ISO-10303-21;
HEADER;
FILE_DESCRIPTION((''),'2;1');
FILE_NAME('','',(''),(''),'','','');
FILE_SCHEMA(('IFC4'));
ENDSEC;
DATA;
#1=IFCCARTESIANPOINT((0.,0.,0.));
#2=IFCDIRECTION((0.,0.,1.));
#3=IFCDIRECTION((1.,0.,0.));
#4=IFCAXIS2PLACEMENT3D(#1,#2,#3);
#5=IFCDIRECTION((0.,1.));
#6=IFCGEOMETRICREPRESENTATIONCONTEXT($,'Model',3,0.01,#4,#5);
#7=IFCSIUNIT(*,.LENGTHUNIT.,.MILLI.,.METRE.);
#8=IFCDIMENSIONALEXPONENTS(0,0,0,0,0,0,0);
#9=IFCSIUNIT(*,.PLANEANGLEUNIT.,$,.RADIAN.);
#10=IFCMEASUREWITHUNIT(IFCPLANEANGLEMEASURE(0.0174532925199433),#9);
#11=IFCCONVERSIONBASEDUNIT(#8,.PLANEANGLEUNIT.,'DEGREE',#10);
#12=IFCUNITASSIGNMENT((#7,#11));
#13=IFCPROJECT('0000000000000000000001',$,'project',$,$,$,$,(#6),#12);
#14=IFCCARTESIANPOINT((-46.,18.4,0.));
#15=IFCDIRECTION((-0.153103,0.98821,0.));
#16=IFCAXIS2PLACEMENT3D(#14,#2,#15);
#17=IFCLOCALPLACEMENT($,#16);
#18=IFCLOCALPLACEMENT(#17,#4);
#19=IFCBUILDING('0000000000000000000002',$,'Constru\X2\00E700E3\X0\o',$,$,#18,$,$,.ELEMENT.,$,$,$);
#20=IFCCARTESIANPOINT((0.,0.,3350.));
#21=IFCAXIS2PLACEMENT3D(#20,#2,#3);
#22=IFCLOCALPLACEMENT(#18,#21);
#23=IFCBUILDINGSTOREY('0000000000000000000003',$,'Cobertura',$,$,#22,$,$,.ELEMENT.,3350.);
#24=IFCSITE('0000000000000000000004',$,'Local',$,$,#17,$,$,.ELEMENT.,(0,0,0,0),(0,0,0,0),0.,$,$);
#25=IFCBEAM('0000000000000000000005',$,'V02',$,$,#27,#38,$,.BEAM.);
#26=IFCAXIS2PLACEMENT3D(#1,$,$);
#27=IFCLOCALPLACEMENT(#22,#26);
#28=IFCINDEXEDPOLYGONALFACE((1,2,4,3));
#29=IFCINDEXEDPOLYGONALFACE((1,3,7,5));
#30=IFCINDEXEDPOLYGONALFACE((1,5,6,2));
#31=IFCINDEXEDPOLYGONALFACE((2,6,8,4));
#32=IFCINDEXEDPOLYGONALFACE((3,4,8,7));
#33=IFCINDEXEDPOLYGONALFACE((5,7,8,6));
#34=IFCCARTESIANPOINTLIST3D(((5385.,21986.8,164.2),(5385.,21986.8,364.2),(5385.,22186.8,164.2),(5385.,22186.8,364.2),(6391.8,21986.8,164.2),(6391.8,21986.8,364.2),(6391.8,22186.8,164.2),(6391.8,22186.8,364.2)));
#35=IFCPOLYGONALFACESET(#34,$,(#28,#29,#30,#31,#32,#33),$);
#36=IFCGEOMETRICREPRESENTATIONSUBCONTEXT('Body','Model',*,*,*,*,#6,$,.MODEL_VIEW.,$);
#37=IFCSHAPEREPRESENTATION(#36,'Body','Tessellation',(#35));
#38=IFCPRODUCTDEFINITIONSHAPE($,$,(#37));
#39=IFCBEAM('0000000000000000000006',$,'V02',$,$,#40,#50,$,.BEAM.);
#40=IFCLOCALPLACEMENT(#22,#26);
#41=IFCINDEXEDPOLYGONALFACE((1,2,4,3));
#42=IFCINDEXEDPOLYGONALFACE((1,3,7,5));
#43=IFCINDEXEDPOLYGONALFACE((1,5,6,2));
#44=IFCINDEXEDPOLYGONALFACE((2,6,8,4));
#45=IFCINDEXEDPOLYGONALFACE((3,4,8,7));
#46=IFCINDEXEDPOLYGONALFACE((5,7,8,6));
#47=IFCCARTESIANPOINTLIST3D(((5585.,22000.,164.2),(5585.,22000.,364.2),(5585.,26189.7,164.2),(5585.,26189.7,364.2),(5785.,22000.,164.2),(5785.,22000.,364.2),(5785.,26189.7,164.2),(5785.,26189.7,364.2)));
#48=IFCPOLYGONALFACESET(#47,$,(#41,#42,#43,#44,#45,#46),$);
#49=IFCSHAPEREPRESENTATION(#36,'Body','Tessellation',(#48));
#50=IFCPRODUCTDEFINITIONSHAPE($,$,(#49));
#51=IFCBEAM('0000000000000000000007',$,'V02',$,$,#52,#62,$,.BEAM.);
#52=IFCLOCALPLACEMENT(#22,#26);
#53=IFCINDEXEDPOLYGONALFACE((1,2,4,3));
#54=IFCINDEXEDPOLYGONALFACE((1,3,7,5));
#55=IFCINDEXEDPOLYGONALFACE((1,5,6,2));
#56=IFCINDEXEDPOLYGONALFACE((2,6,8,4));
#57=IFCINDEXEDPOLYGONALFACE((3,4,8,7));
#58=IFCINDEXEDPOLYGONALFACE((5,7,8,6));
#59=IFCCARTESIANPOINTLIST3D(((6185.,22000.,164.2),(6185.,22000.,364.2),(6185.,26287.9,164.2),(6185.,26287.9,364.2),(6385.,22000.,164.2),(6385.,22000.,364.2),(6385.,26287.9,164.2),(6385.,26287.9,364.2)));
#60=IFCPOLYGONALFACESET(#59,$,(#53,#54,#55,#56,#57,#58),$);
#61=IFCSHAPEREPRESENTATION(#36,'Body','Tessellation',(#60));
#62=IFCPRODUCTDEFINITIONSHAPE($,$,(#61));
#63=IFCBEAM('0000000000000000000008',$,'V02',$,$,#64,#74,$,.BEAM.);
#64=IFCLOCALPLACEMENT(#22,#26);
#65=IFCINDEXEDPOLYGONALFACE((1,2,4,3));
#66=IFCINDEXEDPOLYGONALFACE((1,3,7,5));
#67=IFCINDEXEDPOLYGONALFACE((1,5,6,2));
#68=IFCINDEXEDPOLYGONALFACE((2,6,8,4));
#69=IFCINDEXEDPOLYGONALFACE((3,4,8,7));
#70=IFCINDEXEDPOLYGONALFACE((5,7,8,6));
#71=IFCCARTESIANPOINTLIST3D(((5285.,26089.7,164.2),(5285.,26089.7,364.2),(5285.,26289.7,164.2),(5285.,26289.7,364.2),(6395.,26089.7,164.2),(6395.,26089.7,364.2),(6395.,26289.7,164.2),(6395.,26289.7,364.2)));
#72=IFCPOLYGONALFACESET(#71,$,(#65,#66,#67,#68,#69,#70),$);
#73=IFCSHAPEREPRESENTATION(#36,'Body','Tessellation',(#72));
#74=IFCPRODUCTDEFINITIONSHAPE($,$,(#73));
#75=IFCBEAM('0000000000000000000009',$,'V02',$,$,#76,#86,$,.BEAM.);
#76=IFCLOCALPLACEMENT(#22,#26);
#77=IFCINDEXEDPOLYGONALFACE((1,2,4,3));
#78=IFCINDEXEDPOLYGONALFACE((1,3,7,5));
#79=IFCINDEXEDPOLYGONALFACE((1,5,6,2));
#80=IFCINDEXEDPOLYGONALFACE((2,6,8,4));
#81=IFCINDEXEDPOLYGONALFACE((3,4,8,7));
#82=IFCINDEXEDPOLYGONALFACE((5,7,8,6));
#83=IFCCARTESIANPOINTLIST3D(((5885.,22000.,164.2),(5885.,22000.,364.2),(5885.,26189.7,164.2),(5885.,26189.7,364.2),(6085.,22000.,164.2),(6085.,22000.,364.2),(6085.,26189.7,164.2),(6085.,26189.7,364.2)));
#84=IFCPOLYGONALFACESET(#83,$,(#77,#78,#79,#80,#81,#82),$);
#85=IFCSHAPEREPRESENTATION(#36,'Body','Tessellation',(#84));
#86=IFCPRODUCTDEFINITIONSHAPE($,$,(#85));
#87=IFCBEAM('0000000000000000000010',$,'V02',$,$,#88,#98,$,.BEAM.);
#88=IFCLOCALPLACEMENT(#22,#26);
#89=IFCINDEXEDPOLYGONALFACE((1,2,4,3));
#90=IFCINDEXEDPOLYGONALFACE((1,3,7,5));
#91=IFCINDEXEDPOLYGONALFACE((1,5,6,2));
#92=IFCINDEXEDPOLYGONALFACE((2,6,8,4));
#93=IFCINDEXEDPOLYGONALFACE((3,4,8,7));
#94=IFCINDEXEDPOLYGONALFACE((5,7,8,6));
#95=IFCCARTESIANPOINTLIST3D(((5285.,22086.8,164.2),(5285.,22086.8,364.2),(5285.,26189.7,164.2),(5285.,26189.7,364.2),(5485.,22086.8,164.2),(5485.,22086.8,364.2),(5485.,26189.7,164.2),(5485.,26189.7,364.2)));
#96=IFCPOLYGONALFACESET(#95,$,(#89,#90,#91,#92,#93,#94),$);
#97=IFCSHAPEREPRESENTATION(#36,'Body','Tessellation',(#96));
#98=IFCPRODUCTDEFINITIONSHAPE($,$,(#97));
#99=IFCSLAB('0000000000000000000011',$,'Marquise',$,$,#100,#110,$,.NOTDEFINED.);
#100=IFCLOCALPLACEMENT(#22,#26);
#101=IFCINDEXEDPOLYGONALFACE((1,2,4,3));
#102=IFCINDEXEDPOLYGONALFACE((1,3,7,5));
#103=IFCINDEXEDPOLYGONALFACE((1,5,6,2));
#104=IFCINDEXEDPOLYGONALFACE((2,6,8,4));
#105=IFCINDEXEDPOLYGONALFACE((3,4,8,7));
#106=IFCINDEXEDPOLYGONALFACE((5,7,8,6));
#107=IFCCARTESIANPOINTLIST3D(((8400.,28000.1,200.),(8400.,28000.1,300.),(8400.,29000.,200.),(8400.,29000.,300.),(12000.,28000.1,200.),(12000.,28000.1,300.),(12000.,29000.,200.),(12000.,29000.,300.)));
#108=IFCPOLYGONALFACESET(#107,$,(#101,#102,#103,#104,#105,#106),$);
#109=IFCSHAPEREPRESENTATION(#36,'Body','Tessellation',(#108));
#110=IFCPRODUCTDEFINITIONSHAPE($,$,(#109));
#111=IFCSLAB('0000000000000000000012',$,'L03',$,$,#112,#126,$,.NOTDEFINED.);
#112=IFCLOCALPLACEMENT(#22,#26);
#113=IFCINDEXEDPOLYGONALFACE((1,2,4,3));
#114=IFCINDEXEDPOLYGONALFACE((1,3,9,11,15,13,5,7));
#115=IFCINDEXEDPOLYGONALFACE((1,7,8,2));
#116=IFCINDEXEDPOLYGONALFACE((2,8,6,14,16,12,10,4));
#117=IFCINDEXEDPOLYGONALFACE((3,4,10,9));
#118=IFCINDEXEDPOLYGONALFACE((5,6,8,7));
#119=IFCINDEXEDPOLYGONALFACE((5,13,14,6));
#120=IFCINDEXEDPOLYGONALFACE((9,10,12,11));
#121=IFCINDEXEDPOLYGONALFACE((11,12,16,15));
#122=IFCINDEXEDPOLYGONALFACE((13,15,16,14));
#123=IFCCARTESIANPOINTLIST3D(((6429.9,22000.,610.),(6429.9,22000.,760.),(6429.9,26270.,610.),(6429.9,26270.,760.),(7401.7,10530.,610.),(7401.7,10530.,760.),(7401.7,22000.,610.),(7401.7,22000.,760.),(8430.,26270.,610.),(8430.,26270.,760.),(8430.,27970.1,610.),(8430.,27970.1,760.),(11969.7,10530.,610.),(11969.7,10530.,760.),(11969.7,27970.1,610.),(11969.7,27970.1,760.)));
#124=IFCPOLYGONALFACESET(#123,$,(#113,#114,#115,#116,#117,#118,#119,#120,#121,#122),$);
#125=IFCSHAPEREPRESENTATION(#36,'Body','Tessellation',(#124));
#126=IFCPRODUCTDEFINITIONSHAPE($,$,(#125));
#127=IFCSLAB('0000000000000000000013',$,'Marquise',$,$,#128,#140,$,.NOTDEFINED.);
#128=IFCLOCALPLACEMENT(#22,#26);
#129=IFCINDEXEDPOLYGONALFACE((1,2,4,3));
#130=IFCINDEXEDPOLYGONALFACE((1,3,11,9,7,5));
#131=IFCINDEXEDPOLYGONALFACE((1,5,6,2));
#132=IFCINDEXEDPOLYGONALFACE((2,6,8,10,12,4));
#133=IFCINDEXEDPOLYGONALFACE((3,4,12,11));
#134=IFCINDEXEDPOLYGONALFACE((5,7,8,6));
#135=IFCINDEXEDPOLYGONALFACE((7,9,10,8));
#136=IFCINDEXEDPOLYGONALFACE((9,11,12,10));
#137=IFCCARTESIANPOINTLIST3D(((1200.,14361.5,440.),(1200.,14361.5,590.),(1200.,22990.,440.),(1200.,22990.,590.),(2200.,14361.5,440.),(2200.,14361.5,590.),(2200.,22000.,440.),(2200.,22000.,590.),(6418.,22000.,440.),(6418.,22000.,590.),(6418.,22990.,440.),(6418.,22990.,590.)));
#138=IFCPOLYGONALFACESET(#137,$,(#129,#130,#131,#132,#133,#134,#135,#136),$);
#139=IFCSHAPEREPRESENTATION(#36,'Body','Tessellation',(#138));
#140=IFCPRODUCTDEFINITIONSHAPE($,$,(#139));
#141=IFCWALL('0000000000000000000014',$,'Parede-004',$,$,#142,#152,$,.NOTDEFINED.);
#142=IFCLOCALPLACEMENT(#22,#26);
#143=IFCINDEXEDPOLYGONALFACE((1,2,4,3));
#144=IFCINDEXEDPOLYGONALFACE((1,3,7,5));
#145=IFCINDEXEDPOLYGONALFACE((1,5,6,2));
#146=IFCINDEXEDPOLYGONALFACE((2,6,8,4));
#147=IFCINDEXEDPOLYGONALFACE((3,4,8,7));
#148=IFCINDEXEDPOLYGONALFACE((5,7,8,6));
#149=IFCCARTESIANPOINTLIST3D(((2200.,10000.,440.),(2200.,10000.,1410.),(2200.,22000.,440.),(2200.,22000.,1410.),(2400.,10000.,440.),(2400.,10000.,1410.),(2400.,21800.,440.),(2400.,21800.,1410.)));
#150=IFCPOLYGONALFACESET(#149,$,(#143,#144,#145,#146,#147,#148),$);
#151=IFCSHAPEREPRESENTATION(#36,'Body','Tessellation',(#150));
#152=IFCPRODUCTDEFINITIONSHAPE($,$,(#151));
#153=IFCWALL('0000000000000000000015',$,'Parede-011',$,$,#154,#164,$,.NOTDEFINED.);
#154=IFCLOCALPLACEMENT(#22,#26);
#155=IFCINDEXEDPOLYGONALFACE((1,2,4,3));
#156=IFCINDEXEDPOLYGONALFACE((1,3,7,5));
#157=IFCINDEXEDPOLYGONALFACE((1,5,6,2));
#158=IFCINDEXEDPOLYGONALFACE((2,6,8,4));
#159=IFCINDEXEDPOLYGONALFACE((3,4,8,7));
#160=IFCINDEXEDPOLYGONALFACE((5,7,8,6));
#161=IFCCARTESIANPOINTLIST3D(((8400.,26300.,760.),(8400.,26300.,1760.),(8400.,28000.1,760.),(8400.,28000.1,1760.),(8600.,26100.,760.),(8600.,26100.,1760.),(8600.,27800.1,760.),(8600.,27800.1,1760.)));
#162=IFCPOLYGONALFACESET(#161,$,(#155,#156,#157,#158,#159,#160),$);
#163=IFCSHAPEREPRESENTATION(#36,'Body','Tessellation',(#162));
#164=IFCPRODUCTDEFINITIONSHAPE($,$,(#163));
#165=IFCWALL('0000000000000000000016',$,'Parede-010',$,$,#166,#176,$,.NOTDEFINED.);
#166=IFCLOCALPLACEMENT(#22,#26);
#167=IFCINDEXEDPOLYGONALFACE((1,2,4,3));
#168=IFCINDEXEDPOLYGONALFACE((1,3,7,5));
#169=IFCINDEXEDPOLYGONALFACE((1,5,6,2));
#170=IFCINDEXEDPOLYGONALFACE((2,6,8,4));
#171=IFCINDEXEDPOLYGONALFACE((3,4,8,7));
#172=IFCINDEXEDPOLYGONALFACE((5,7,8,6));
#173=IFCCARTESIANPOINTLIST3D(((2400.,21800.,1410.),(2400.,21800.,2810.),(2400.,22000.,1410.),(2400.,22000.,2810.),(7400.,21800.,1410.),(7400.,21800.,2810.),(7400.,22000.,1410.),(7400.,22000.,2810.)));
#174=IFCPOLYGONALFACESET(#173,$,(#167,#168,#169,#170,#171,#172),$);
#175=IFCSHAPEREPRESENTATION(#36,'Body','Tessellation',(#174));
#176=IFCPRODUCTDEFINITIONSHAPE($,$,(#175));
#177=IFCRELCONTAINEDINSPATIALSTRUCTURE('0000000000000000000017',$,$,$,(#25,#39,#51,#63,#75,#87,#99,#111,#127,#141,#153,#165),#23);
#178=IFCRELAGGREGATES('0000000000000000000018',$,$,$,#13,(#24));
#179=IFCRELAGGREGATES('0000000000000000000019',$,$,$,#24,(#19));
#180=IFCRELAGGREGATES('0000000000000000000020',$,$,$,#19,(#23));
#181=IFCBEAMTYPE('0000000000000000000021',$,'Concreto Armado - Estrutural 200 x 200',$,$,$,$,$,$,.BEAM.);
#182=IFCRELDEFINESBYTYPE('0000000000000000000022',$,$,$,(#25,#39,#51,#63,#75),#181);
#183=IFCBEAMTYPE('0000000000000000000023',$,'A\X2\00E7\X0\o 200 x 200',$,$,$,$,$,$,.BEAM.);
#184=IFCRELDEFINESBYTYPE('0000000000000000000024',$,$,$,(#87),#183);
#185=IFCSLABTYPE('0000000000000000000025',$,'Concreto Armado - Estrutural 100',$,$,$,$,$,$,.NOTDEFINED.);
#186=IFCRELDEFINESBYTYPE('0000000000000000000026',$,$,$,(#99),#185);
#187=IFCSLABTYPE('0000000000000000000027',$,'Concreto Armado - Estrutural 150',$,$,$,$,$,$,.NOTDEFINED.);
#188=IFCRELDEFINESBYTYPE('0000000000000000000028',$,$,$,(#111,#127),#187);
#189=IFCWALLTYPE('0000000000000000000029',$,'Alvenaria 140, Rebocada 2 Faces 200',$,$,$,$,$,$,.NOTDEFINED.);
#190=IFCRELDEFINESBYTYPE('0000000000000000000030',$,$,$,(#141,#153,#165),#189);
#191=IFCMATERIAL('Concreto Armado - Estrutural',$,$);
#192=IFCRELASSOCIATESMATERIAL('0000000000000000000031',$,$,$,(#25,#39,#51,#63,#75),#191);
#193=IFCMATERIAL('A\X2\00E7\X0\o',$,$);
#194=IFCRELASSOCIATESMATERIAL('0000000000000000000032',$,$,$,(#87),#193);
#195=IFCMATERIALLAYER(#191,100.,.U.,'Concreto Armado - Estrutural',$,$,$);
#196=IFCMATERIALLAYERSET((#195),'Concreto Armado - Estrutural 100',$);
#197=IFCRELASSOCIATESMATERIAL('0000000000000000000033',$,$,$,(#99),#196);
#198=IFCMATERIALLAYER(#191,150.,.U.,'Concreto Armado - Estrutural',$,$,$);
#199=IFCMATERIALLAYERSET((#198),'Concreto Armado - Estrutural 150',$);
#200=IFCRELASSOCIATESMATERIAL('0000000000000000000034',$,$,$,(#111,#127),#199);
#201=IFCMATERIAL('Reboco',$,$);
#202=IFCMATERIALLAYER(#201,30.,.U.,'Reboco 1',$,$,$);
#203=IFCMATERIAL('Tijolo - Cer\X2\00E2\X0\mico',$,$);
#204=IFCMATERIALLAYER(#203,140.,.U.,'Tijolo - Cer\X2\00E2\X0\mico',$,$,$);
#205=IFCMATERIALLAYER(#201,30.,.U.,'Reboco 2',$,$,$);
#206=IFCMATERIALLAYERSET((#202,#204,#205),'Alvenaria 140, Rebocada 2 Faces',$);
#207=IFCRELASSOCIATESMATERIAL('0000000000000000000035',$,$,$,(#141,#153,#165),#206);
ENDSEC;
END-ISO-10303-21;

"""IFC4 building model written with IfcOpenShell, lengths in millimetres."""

from ifc_helpers import new_model, entity, si_unit, converted_unit, direction, frame, frame_2d, origin_with_axes, place, context, subcontext, project, spatial, line, indexed_curve, rectangle, outline, extrude, material, layer, layer_set, layer_usage, type_object, element, save


model = new_model("IFC4")

# Units and contexts
model_context = context("Model", 3, precision=0.01, world=origin_with_axes(), true_north=direction((0.0, 1.0)))
body_context = subcontext(model_context, "Body", "Model", "MODEL_VIEW")
ifc_project = project(units=[si_unit("LENGTHUNIT", "METRE", prefix="MILLI"), converted_unit("PLANEANGLEUNIT", "DEGREE", entity("IfcPlaneAngleMeasure", 0.0174532925199433), si_unit("PLANEANGLEUNIT", "RADIAN"), dimensions=[0, 0, 0, 0, 0, 0, 0])], contexts=[model_context])

# Site, building, storey
site_placement = place(None, frame((-46.0, 18.4, 0.0), z_axis=(0.0, 0.0, 1.0), x_axis=(-0.153103, 0.98821, 0.0)))
site = spatial("IfcSite", under=ifc_project, at=site_placement, Name="Local", CompositionType="ELEMENT", RefLatitude=(0, 0, 0, 0), RefLongitude=(0, 0, 0, 0), RefElevation=0.0)
building_placement = place(site_placement, origin_with_axes())
building = spatial("IfcBuilding", under=site, at=building_placement, Name="Construção", CompositionType="ELEMENT")
storey_placement = place(building_placement, frame((0.0, 0.0, 3350.0), z_axis=(0.0, 0.0, 1.0), x_axis=(1.0, 0.0, 0.0)))
storey = spatial("IfcBuildingStorey", under=building, at=storey_placement, Name="Cobertura", CompositionType="ELEMENT", Elevation=3350.0)

# Beams
ifc_material_1 = material(Name="Concreto Armado - Estrutural")
beam_type_1 = type_object("IfcBeamType", Name="Concreto Armado - Estrutural 200 x 200", PredefinedType="BEAM")
beam_1_placement = place(storey_placement, frame((5385.0, 22086.8, 364.2), z_axis=(0.0, 0.0, 1.0), x_axis=(0.0, -1.0, 0.0)))
element("IfcBeam", 1, at=beam_1_placement, inside=storey, type_object=beam_type_1, material=ifc_material_1, Name="V02", PredefinedType="BEAM", context=body_context, shape_type="SweptSolid", body=[
    extrude(rectangle(XDim=200.0, YDim=200.0, at=frame_2d((-100.0, 0.0), x_axis=(1.0, 0.0))), frame((0.0, 0.0, 0.0), z_axis=(0.0, 1.0, 0.0), x_axis=(0.0, 0.0, 1.0)), (0.0, 0.0, 1.0), 1006.8),
])
beam_2_placement = place(storey_placement, frame((5685.0, 26189.7, 364.2), z_axis=(0.0, 0.0, 1.0), x_axis=(-1.0, 0.0, 0.0)))
element("IfcBeam", 2, at=beam_2_placement, inside=storey, type_object=beam_type_1, material=ifc_material_1, Name="V02", PredefinedType="BEAM", context=body_context, shape_type="SweptSolid", body=[
    extrude(rectangle(XDim=200.0, YDim=200.0, at=frame_2d((-100.0, 0.0), x_axis=(1.0, 0.0))), frame((0.0, 0.0, 0.0), z_axis=(0.0, 1.0, 0.0), x_axis=(0.0, 0.0, 1.0)), (0.0, 0.0, 1.0), 4189.7),
])
beam_3_placement = place(storey_placement, frame((6285.0, 26287.9, 364.2), z_axis=(0.0, 0.0, 1.0), x_axis=(-1.0, 0.0, 0.0)))
element("IfcBeam", 3, at=beam_3_placement, inside=storey, type_object=beam_type_1, material=ifc_material_1, Name="V02", PredefinedType="BEAM", context=body_context, shape_type="SweptSolid", body=[
    extrude(rectangle(XDim=200.0, YDim=200.0, at=frame_2d((-100.0, 0.0), x_axis=(1.0, 0.0))), frame((0.0, 0.0, 0.0), z_axis=(0.0, 1.0, 0.0), x_axis=(0.0, 0.0, 1.0)), (0.0, 0.0, 1.0), 4287.8),
])
beam_4_placement = place(storey_placement, frame((5285.0, 26189.7, 364.2), z_axis=(0.0, 0.0, 1.0), x_axis=(0.0, -1.0, 0.0)))
element("IfcBeam", 4, at=beam_4_placement, inside=storey, type_object=beam_type_1, material=ifc_material_1, Name="V02", PredefinedType="BEAM", context=body_context, shape_type="SweptSolid", body=[
    extrude(rectangle(XDim=200.0, YDim=200.0, at=frame_2d((-100.0, 0.0), x_axis=(1.0, 0.0))), frame((0.0, 0.0, 0.0), z_axis=(0.0, 1.0, 0.0), x_axis=(0.0, 0.0, 1.0)), (0.0, 0.0, 1.0), 1109.9),
])
beam_5_placement = place(storey_placement, frame((5985.0, 26189.7, 364.2), z_axis=(0.0, 0.0, 1.0), x_axis=(-1.0, 0.0, 0.0)))
element("IfcBeam", 5, at=beam_5_placement, inside=storey, type_object=beam_type_1, material=ifc_material_1, Name="V02", PredefinedType="BEAM", context=body_context, shape_type="SweptSolid", body=[
    extrude(rectangle(XDim=200.0, YDim=200.0, at=frame_2d((-100.0, 0.0), x_axis=(1.0, 0.0))), frame((0.0, 0.0, 0.0), z_axis=(0.0, 1.0, 0.0), x_axis=(0.0, 0.0, 1.0)), (0.0, 0.0, 1.0), 4189.7),
])
ifc_material_2 = material(Name="Aço")
beam_type_2 = type_object("IfcBeamType", Name="Aço 200 x 200", PredefinedType="BEAM")
beam_6_placement = place(storey_placement, frame((5385.0, 26189.7, 364.2), z_axis=(0.0, 0.0, 1.0), x_axis=(-1.0, 0.0, 0.0)))
element("IfcBeam", 6, at=beam_6_placement, inside=storey, type_object=beam_type_2, material=ifc_material_2, Name="V02", PredefinedType="BEAM", context=body_context, shape_type="SweptSolid", body=[
    extrude(rectangle(XDim=200.0, YDim=200.0, at=frame_2d((-100.0, 0.0), x_axis=(1.0, 0.0))), frame((0.0, 0.0, 0.0), z_axis=(0.0, 1.0, 0.0), x_axis=(0.0, 0.0, 1.0)), (0.0, 0.0, 1.0), 4102.9),
])

# Slabs
ifc_layer_1 = layer(ifc_material_1, 100.0, ventilated="UNKNOWN", Name="Concreto Armado - Estrutural")
ifc_layer_set_1 = layer_set([ifc_layer_1], Name="Concreto Armado - Estrutural 100")
ifc_layer_usage_1 = layer_usage(ifc_layer_set_1, "AXIS3", "NEGATIVE", 100.0)
slab_type_1 = type_object("IfcSlabType", Name="Concreto Armado - Estrutural 100", PredefinedType="NOTDEFINED")
slab_1_placement = place(storey_placement, frame((8400.0, 28000.1, 300.0), z_axis=(0.0, 0.0, 1.0), x_axis=(1.0, 0.0, 0.0)))
element("IfcSlab", 7, at=slab_1_placement, inside=storey, type_object=slab_type_1, material=ifc_layer_usage_1, Name="Marquise", PredefinedType="NOTDEFINED", context=body_context, shape_type="SweptSolid", body=[
    extrude(outline(indexed_curve([(0.0, 0.0), (3600.0, 0.0), (3600.0, 999.9), (0.0, 999.9)], segments=[line(1, 2, 3, 4, 1)])), frame((0.0, 0.0, -100.0), z_axis=(0.0, 0.0, 1.0), x_axis=(1.0, 0.0, 0.0)), (0.0, 0.0, 1.0), 100.0),
])
ifc_layer_2 = layer(ifc_material_1, 150.0, ventilated="UNKNOWN", Name="Concreto Armado - Estrutural")
ifc_layer_set_2 = layer_set([ifc_layer_2], Name="Concreto Armado - Estrutural 150")
ifc_layer_usage_2 = layer_usage(ifc_layer_set_2, "AXIS3", "NEGATIVE", 150.0)
slab_type_2 = type_object("IfcSlabType", Name="Concreto Armado - Estrutural 150", PredefinedType="NOTDEFINED")
slab_2_placement = place(storey_placement, frame((6429.9, 22000.0, 760.0), z_axis=(0.0, 0.0, 1.0), x_axis=(1.0, 0.0, 0.0)))
element("IfcSlab", 8, at=slab_2_placement, inside=storey, type_object=slab_type_2, material=ifc_layer_usage_2, Name="L03", PredefinedType="NOTDEFINED", context=body_context, shape_type="SweptSolid", body=[
    extrude(outline(indexed_curve([(0.0, 0.0), (971.8, 0.0), (971.8, -11470.0), (5539.7, -11470.0), (5539.7, 5970.0), (2000.0, 5970.0), (2000.0, 4270.0), (0.0, 4270.0)], segments=[line(1, 2, 3, 4, 5, 6, 7, 8, 1)])), frame((0.0, 0.0, -150.0), z_axis=(0.0, 0.0, 1.0), x_axis=(1.0, 0.0, 0.0)), (0.0, 0.0, 1.0), 150.0),
])
ifc_layer_usage_3 = layer_usage(ifc_layer_set_2, "AXIS3", "NEGATIVE", 150.0)
slab_3_placement = place(storey_placement, frame((1200.0, 14361.5, 590.0), z_axis=(0.0, 0.0, 1.0), x_axis=(1.0, 0.0, 0.0)))
element("IfcSlab", 9, at=slab_3_placement, inside=storey, type_object=slab_type_2, material=ifc_layer_usage_3, Name="Marquise", PredefinedType="NOTDEFINED", context=body_context, shape_type="SweptSolid", body=[
    extrude(outline(indexed_curve([(0.0, 0.0), (1000.0, 0.0), (1000.0, 7638.5), (5218.0, 7638.5), (5218.0, 8628.5), (0.0, 8628.5)], segments=[line(1, 2, 3, 4, 5, 6, 1)])), frame((0.0, 0.0, -150.0), z_axis=(0.0, 0.0, 1.0), x_axis=(1.0, 0.0, 0.0)), (0.0, 0.0, 1.0), 150.0),
])

# Walls
ifc_material_3 = material(Name="Reboco")
ifc_layer_3 = layer(ifc_material_3, 30.0, ventilated="UNKNOWN", Name="Reboco 1")
ifc_material_4 = material(Name="Tijolo - Cerâmico")
ifc_layer_4 = layer(ifc_material_4, 140.0, ventilated="UNKNOWN", Name="Tijolo - Cerâmico")
ifc_layer_5 = layer(ifc_material_3, 30.0, ventilated="UNKNOWN", Name="Reboco 2")
ifc_layer_set_3 = layer_set([ifc_layer_3, ifc_layer_4, ifc_layer_5], Name="Alvenaria 140, Rebocada 2 Faces")
ifc_layer_usage_4 = layer_usage(ifc_layer_set_3, "AXIS2", "POSITIVE", 0.0)
wall_type = type_object("IfcWallType", Name="Alvenaria 140, Rebocada 2 Faces 200", PredefinedType="NOTDEFINED")
wall_1_placement = place(storey_placement, frame((2200.0, 22000.0, 440.0), z_axis=(0.0, 0.0, 1.0), x_axis=(0.0, -1.0, 0.0)))
element("IfcWall", 10, at=wall_1_placement, inside=storey, type_object=wall_type, material=ifc_layer_usage_4, Name="Parede-004", PredefinedType="NOTDEFINED", context=body_context, shape_type="SweptSolid", body=[
    extrude(outline(indexed_curve([(0.0, 0.0), (12000.0, 0.0), (12000.0, 200.0), (200.0, 200.0)], segments=[line(1, 2, 3, 4, 1)])), origin_with_axes(), (0.0, 0.0, 1.0), 970.0),
])
ifc_layer_usage_5 = layer_usage(ifc_layer_set_3, "AXIS2", "NEGATIVE", 0.0)
wall_2_placement = place(storey_placement, frame((8400.0, 26300.0, 760.0), z_axis=(0.0, 0.0, 1.0), x_axis=(0.0, 1.0, 0.0)))
element("IfcWall", 11, at=wall_2_placement, inside=storey, type_object=wall_type, material=ifc_layer_usage_5, Name="Parede-011", PredefinedType="NOTDEFINED", context=body_context, shape_type="SweptSolid", body=[
    extrude(outline(indexed_curve([(-200.0, -200.0), (1500.1, -200.0), (1700.1, 0.0), (0.0, 0.0)], segments=[line(1, 2, 3, 4, 1)])), origin_with_axes(), (0.0, 0.0, 1.0), 1000.0),
])
ifc_layer_usage_6 = layer_usage(ifc_layer_set_3, "AXIS2", "POSITIVE", 0.0)
wall_3_placement = place(storey_placement, frame((7400.0, 22000.0, 1410.0), z_axis=(0.0, 0.0, 1.0), x_axis=(-1.0, -0.000003, 0.0)))
element("IfcWall", 12, at=wall_3_placement, inside=storey, type_object=wall_type, material=ifc_layer_usage_6, Name="Parede-010", PredefinedType="NOTDEFINED", context=body_context, shape_type="SweptSolid", body=[
    extrude(outline(indexed_curve([(0.0, 0.0), (5000.0, 0.0), (5000.0, 200.0), (0.0, 200.0)], segments=[line(1, 2, 3, 4, 1)])), origin_with_axes(), (0.0, 0.0, 1.0), 1400.0),
])

save(model, "model.ifc")
